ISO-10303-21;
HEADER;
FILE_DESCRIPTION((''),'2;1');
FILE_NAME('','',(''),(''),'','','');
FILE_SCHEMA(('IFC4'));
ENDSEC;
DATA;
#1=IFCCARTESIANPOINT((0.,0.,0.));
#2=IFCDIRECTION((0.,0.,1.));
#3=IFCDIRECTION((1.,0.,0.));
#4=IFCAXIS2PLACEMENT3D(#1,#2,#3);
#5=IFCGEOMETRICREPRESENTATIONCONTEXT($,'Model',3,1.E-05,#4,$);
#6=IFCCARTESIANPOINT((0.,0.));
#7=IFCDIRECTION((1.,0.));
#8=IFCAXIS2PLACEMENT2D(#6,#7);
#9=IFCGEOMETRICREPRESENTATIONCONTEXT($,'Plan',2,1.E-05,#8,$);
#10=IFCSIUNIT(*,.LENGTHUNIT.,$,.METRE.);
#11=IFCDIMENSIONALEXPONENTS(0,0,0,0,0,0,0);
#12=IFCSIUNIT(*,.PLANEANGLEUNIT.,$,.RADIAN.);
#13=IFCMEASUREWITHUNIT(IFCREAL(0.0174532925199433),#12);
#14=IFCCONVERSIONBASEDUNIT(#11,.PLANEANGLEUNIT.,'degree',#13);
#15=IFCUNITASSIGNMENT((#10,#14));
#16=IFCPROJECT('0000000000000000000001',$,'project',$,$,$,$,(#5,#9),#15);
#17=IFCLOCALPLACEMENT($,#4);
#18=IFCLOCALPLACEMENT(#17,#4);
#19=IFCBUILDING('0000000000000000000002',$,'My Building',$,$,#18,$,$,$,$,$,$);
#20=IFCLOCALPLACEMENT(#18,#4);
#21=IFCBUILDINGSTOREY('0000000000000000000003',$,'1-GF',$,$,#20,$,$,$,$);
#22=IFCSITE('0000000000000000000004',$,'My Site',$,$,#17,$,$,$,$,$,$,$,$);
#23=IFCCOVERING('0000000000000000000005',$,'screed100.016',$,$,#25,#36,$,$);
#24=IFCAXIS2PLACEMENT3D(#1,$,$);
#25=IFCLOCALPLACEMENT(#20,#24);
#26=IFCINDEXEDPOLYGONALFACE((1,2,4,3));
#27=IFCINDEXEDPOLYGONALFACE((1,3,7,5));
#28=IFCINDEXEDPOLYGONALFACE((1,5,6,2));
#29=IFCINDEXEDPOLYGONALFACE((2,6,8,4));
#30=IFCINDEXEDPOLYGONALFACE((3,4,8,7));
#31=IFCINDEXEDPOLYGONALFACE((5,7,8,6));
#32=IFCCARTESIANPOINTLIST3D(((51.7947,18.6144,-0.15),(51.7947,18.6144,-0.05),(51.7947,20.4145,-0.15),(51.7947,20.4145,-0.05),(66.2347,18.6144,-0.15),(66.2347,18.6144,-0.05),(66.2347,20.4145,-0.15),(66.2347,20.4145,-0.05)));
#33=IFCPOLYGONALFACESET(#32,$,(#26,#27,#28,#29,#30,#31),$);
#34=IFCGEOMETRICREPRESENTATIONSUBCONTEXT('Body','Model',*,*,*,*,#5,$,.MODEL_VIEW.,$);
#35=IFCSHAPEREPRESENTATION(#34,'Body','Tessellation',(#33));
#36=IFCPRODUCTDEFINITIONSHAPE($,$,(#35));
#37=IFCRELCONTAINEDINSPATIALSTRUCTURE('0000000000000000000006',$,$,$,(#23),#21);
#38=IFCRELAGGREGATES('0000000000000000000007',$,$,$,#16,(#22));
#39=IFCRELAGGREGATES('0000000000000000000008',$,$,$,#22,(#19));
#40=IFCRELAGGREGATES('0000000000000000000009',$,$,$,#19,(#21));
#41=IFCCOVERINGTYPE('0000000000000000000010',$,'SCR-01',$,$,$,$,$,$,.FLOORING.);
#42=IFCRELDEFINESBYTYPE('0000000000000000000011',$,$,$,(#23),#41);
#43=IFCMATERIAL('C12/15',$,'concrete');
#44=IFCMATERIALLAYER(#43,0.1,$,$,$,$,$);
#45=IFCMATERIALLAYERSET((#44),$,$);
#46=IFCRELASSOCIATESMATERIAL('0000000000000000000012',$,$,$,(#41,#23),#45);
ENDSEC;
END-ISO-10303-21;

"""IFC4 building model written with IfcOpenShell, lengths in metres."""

from ifc_helpers import new_model, entity, si_unit, converted_unit, frame, origin_with_axes, origin_2d_with_axis, place, context, subcontext, project, spatial, line, indexed_curve, outline, extrude, material, layer, layer_set, layer_usage, type_object, element, save


model = new_model("IFC4")

# Units and contexts
model_context = context("Model", 3, precision=1e-05, world=origin_with_axes())
plan_context = context("Plan", 2, precision=1e-05, world=origin_2d_with_axis())
body_context_1 = subcontext(model_context, "Body", "Model", "MODEL_VIEW")
ifc_project = project(units=[si_unit("LENGTHUNIT", "METRE"), converted_unit("PLANEANGLEUNIT", "degree", entity("IfcReal", 0.0174532925199433), si_unit("PLANEANGLEUNIT", "RADIAN"), dimensions=[0, 0, 0, 0, 0, 0, 0])], contexts=[model_context, plan_context])

# Site, building, storey
site_placement = place(None, origin_with_axes())
site = spatial("IfcSite", under=ifc_project, at=site_placement, Name="My Site")
building_placement = place(site_placement, origin_with_axes())
building = spatial("IfcBuilding", under=site, at=building_placement, Name="My Building")
storey_placement = place(building_placement, origin_with_axes())
storey = spatial("IfcBuildingStorey", under=building, at=storey_placement, Name="1-GF")

# Covering
ifc_material_1 = material(Name="C12/15", Category="concrete")
ifc_layer_1 = layer(ifc_material_1, 0.1)
ifc_layer_set_1 = layer_set([ifc_layer_1])
covering_type_1 = type_object("IfcCoveringType", Name="SCR-01", PredefinedType="FLOORING", material=ifc_layer_set_1)
ifc_layer_usage_1 = layer_usage(ifc_layer_set_1, "AXIS3", "POSITIVE", 0.0)
covering_1_placement = place(storey_placement, frame((51.7947, 18.6144, -0.15), z_axis=(0.0, 0.0, 1.0), x_axis=(1.0, 0.0, 0.0)))
element("IfcCovering", 1, at=covering_1_placement, inside=storey, type_object=covering_type_1, material=ifc_layer_usage_1, Name="screed100.016", context=body_context_1, shape_type="SweptSolid", body=[
    extrude(outline(indexed_curve([(0.0, 0.0), (14.44, 0.0), (14.44, 1.8001), (0.0, 1.8001)], segments=[line(4, 1), line(1, 2), line(2, 3), line(3, 4)], self_intersect=False)), None, (0.0, 0.0, 1.0), 0.1),
])

save(model, "model.ifc")
